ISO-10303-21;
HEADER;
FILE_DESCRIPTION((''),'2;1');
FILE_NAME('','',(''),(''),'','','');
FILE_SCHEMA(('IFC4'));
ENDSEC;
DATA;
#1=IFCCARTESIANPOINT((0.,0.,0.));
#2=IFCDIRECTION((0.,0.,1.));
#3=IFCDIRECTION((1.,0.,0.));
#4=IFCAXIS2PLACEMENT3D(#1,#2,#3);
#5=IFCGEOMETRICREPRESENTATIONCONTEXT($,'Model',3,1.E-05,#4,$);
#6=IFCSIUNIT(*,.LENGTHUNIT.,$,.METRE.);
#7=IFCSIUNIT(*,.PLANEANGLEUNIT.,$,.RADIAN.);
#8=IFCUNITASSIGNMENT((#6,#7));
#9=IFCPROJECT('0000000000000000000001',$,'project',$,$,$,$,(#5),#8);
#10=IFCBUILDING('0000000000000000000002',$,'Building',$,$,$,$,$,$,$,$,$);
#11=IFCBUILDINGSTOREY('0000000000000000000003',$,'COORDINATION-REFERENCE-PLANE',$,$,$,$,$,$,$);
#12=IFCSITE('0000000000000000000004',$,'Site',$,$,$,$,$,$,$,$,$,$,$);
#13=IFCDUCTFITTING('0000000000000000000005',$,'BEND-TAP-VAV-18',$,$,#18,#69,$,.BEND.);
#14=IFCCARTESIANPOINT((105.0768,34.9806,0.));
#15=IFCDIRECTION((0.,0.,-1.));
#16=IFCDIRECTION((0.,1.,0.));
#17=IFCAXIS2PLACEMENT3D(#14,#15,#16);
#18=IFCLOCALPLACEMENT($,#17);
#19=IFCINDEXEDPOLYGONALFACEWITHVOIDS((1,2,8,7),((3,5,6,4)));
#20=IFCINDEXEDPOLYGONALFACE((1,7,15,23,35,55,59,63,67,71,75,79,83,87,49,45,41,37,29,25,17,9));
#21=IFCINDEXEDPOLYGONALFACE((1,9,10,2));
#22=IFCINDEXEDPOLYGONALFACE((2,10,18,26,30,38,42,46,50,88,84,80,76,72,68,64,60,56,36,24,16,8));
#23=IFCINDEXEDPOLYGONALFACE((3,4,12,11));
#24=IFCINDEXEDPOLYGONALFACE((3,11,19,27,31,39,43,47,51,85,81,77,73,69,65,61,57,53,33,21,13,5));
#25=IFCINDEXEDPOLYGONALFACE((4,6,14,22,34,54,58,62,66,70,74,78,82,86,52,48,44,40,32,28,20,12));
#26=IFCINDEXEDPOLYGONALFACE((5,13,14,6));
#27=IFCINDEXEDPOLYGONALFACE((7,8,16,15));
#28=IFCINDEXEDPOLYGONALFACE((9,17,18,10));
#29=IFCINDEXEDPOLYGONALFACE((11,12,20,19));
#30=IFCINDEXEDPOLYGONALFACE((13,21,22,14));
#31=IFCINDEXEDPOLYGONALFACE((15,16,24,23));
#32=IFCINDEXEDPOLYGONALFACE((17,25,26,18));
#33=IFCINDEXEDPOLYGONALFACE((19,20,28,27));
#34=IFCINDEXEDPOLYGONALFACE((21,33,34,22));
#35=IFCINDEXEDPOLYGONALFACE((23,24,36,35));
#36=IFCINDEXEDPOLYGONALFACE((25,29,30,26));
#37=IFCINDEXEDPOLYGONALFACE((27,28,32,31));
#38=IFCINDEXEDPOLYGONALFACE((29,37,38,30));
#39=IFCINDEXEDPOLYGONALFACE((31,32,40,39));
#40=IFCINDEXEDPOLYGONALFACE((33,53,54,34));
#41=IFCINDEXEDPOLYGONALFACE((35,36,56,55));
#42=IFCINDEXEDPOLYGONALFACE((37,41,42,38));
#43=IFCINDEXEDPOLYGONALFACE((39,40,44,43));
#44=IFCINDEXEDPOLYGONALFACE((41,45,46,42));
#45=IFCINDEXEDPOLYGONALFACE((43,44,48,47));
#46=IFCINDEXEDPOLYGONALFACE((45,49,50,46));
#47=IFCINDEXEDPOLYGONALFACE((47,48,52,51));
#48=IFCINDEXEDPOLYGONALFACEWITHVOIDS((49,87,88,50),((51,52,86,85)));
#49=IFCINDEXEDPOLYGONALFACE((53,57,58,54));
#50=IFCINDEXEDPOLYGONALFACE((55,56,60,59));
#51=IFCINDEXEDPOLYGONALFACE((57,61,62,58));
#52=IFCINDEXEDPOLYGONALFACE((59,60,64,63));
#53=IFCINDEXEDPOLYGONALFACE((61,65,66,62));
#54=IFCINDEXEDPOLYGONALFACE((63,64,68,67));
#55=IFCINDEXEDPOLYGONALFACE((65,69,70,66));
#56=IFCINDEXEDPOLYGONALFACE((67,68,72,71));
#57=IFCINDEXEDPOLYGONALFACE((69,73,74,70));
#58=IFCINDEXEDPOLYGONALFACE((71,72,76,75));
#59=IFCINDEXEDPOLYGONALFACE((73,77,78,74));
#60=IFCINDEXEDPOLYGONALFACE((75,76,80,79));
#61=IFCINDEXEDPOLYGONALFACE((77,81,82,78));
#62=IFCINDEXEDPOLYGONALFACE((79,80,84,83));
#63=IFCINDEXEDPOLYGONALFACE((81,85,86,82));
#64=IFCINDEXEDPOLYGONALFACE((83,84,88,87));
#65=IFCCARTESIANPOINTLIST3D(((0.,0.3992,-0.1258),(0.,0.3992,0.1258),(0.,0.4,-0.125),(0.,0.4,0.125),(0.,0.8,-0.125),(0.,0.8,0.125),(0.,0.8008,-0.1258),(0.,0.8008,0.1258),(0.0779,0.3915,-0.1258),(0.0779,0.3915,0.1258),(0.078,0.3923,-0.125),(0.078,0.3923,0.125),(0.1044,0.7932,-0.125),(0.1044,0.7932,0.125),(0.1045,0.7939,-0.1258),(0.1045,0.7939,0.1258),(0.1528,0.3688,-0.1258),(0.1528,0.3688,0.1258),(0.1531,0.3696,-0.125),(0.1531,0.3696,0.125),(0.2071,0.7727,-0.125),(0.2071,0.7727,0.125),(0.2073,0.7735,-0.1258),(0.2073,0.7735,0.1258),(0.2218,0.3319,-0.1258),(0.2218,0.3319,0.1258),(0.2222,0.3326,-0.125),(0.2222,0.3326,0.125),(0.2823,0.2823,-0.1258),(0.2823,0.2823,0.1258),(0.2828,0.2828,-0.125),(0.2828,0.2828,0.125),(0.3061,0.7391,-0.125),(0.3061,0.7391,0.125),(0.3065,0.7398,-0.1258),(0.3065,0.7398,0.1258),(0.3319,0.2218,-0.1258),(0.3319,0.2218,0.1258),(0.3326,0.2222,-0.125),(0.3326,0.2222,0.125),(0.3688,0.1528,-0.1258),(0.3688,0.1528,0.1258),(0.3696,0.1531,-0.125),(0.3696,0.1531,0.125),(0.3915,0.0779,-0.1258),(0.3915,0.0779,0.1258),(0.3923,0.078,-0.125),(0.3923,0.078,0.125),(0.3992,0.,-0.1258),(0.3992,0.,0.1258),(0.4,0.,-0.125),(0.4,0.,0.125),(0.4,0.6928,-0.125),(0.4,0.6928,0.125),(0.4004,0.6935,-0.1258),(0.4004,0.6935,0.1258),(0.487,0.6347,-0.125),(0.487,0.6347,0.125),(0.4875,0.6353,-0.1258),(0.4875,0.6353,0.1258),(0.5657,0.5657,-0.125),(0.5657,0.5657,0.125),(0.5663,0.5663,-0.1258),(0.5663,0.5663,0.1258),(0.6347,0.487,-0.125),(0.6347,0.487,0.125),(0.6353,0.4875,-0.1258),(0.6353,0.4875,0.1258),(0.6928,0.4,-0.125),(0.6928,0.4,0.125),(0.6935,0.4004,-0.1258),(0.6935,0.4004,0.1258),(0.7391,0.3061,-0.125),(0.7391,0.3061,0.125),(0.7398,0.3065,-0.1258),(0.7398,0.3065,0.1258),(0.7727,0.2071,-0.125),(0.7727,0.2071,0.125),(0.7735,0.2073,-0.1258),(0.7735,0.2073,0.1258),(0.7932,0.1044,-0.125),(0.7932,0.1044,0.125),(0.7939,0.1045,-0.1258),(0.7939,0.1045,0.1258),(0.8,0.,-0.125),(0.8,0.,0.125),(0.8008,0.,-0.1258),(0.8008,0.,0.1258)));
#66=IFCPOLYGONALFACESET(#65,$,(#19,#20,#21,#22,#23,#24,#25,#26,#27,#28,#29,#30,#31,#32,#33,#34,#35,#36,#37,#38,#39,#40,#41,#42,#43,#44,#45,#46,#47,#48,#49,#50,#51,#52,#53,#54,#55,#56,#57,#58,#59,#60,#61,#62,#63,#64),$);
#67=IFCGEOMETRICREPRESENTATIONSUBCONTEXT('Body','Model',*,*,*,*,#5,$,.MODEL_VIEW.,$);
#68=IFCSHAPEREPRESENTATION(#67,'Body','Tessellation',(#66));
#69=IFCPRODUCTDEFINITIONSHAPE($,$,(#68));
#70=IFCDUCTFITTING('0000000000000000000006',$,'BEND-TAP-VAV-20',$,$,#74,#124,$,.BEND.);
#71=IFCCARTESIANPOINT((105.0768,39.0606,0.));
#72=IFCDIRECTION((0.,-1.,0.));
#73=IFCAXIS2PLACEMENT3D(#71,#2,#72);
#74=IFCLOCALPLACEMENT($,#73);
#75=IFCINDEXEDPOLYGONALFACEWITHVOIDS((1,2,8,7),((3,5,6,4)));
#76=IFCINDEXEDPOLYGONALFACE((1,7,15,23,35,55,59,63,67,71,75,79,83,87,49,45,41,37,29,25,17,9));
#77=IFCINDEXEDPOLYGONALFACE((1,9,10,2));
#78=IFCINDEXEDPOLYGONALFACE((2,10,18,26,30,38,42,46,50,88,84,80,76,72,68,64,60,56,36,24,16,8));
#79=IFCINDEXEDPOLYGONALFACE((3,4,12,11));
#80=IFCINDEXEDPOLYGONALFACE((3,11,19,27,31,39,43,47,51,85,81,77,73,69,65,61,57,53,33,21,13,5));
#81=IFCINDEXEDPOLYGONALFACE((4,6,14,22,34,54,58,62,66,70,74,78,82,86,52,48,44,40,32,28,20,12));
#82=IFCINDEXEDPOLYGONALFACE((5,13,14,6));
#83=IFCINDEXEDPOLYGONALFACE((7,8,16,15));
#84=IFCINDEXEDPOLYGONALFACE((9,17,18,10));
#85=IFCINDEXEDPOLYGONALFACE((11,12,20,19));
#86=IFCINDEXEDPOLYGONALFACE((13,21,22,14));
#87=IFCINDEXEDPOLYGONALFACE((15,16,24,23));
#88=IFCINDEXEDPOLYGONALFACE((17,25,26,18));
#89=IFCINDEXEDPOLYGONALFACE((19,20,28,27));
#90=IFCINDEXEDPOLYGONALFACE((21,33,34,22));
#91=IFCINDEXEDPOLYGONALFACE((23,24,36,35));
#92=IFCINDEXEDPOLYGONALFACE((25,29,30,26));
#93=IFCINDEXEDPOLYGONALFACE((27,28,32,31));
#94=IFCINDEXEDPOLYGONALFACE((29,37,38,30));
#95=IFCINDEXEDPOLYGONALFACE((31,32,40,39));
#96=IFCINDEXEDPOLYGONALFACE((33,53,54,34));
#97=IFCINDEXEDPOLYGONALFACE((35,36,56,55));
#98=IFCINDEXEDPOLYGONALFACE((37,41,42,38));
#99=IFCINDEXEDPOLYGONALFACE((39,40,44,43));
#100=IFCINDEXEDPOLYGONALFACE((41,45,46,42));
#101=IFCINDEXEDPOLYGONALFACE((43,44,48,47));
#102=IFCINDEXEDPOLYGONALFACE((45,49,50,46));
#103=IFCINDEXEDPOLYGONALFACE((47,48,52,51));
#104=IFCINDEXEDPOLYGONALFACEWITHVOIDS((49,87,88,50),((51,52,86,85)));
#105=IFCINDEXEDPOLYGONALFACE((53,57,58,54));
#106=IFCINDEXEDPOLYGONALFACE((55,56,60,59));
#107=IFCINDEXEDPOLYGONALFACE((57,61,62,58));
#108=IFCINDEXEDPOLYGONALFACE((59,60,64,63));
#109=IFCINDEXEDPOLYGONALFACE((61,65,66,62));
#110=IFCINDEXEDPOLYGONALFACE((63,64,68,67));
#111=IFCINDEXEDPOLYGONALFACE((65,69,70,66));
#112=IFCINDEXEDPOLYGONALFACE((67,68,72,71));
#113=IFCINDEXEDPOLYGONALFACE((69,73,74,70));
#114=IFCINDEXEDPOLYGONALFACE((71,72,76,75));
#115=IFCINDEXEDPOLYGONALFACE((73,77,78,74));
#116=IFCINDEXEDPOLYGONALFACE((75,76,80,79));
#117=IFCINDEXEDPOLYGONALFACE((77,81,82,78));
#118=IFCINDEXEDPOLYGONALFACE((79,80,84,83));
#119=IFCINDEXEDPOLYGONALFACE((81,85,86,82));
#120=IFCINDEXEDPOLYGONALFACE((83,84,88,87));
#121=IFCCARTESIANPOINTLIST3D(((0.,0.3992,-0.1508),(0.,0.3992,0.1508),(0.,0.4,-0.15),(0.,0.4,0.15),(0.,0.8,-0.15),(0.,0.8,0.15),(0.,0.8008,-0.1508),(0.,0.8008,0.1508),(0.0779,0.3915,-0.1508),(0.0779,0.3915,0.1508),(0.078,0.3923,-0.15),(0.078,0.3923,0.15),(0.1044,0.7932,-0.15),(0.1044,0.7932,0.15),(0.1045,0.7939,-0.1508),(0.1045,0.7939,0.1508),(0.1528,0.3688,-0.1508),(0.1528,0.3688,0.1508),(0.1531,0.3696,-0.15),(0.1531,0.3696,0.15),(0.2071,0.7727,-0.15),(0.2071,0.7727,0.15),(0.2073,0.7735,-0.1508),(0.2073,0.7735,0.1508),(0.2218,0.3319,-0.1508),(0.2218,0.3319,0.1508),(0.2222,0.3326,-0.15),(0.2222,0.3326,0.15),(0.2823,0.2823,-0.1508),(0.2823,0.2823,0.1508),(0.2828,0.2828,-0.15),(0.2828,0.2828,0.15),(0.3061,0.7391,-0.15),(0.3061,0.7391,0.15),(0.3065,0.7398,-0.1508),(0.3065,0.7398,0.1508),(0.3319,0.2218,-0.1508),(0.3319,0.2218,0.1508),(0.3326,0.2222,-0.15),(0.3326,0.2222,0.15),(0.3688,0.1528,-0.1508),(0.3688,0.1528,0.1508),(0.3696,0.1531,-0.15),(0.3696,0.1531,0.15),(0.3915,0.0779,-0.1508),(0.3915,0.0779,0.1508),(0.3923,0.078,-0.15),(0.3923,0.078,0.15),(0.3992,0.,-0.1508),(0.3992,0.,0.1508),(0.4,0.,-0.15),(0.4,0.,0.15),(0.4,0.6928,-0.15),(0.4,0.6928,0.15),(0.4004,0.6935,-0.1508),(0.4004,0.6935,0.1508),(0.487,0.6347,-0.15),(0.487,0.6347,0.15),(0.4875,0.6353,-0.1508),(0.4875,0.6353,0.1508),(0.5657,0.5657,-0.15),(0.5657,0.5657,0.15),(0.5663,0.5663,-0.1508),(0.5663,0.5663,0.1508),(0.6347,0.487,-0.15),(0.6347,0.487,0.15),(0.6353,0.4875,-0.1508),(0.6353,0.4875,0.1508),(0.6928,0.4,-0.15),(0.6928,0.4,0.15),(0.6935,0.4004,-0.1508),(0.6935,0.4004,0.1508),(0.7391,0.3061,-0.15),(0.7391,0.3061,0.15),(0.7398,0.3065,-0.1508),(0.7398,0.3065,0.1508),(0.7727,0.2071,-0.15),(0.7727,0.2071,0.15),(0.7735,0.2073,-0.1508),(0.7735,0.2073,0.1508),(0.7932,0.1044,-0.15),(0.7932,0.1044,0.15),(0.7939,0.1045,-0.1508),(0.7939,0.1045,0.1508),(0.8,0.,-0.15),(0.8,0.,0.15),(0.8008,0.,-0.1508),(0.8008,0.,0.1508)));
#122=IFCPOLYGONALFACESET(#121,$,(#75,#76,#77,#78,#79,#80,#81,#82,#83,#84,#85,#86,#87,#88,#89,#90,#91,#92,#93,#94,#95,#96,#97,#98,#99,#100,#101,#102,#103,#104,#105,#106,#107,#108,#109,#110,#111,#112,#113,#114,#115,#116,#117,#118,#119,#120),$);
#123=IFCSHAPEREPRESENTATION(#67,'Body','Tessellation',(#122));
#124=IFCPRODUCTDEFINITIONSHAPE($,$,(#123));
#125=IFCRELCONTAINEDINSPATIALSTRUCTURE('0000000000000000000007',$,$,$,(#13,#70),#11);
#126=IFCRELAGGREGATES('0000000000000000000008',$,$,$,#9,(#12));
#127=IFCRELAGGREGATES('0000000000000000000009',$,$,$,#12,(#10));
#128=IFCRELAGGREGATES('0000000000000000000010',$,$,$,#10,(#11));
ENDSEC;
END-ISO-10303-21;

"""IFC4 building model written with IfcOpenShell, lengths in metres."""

from ifc_helpers import new_model, entity, si_unit, frame, origin_with_axes, place, context, subcontext, project, spatial, element, save


model = new_model("IFC4")

# Units and contexts
model_context_1 = context("Model", 3, precision=1e-05, world=origin_with_axes())
body_context_1 = subcontext(model_context_1, "Body", "Model", "MODEL_VIEW")
ifc_project = project(units=[si_unit("LENGTHUNIT", "METRE"), si_unit("PLANEANGLEUNIT", "RADIAN")], contexts=[model_context_1])

# Site, building, storey
site = spatial("IfcSite", under=ifc_project, Name="Site")
building = spatial("IfcBuilding", under=site, Name="Building")
storey = spatial("IfcBuildingStorey", under=building, Name="COORDINATION-REFERENCE-PLANE")

# Duct fittings
duct_fitting_1_placement = place(None, frame((105.0768, 34.9806, 0.0), z_axis=(0.0, 0.0, -1.0), x_axis=(0.0, 1.0, 0.0)))
cartesian_point_1 = entity("IfcCartesianPoint", [0.0, 0.0, 0.0])
element("IfcDuctFitting", 1, at=duct_fitting_1_placement, inside=storey, Name="BEND-TAP-VAV-18", PredefinedType="BEND", context=body_context_1, shape_type="SweptSolid", body=[
    entity("IfcRevolvedAreaSolid", entity("IfcRectangleHollowProfileDef", "AREA", None, entity("IfcAxis2Placement2D", entity("IfcCartesianPoint", [0.6, 0.0])), 0.4016, 0.2516, 0.0008), entity("IfcAxis2Placement3D", cartesian_point_1, entity("IfcDirection", [0.0, -1.0, 0.0]), entity("IfcDirection", [1.0, 0.0, 0.0])), entity("IfcAxis1Placement", cartesian_point_1, entity("IfcDirection", [0.0, 1.0, 0.0])), 1.570796),
])
duct_fitting_2_placement = place(None, frame((105.0768, 39.0606, 0.0), z_axis=(0.0, 0.0, 1.0), x_axis=(0.0, -1.0, 0.0)))
cartesian_point_2 = entity("IfcCartesianPoint", [0.0, 0.0, 0.0])
element("IfcDuctFitting", 2, at=duct_fitting_2_placement, inside=storey, Name="BEND-TAP-VAV-20", PredefinedType="BEND", context=body_context_1, shape_type="SweptSolid", body=[
    entity("IfcRevolvedAreaSolid", entity("IfcRectangleHollowProfileDef", "AREA", None, entity("IfcAxis2Placement2D", entity("IfcCartesianPoint", [0.6, 0.0])), 0.4016, 0.3016, 0.0008), entity("IfcAxis2Placement3D", cartesian_point_2, entity("IfcDirection", [0.0, -1.0, 0.0]), entity("IfcDirection", [1.0, 0.0, 0.0])), entity("IfcAxis1Placement", cartesian_point_2, entity("IfcDirection", [0.0, 1.0, 0.0])), 1.570796),
])

save(model, "model.ifc")
